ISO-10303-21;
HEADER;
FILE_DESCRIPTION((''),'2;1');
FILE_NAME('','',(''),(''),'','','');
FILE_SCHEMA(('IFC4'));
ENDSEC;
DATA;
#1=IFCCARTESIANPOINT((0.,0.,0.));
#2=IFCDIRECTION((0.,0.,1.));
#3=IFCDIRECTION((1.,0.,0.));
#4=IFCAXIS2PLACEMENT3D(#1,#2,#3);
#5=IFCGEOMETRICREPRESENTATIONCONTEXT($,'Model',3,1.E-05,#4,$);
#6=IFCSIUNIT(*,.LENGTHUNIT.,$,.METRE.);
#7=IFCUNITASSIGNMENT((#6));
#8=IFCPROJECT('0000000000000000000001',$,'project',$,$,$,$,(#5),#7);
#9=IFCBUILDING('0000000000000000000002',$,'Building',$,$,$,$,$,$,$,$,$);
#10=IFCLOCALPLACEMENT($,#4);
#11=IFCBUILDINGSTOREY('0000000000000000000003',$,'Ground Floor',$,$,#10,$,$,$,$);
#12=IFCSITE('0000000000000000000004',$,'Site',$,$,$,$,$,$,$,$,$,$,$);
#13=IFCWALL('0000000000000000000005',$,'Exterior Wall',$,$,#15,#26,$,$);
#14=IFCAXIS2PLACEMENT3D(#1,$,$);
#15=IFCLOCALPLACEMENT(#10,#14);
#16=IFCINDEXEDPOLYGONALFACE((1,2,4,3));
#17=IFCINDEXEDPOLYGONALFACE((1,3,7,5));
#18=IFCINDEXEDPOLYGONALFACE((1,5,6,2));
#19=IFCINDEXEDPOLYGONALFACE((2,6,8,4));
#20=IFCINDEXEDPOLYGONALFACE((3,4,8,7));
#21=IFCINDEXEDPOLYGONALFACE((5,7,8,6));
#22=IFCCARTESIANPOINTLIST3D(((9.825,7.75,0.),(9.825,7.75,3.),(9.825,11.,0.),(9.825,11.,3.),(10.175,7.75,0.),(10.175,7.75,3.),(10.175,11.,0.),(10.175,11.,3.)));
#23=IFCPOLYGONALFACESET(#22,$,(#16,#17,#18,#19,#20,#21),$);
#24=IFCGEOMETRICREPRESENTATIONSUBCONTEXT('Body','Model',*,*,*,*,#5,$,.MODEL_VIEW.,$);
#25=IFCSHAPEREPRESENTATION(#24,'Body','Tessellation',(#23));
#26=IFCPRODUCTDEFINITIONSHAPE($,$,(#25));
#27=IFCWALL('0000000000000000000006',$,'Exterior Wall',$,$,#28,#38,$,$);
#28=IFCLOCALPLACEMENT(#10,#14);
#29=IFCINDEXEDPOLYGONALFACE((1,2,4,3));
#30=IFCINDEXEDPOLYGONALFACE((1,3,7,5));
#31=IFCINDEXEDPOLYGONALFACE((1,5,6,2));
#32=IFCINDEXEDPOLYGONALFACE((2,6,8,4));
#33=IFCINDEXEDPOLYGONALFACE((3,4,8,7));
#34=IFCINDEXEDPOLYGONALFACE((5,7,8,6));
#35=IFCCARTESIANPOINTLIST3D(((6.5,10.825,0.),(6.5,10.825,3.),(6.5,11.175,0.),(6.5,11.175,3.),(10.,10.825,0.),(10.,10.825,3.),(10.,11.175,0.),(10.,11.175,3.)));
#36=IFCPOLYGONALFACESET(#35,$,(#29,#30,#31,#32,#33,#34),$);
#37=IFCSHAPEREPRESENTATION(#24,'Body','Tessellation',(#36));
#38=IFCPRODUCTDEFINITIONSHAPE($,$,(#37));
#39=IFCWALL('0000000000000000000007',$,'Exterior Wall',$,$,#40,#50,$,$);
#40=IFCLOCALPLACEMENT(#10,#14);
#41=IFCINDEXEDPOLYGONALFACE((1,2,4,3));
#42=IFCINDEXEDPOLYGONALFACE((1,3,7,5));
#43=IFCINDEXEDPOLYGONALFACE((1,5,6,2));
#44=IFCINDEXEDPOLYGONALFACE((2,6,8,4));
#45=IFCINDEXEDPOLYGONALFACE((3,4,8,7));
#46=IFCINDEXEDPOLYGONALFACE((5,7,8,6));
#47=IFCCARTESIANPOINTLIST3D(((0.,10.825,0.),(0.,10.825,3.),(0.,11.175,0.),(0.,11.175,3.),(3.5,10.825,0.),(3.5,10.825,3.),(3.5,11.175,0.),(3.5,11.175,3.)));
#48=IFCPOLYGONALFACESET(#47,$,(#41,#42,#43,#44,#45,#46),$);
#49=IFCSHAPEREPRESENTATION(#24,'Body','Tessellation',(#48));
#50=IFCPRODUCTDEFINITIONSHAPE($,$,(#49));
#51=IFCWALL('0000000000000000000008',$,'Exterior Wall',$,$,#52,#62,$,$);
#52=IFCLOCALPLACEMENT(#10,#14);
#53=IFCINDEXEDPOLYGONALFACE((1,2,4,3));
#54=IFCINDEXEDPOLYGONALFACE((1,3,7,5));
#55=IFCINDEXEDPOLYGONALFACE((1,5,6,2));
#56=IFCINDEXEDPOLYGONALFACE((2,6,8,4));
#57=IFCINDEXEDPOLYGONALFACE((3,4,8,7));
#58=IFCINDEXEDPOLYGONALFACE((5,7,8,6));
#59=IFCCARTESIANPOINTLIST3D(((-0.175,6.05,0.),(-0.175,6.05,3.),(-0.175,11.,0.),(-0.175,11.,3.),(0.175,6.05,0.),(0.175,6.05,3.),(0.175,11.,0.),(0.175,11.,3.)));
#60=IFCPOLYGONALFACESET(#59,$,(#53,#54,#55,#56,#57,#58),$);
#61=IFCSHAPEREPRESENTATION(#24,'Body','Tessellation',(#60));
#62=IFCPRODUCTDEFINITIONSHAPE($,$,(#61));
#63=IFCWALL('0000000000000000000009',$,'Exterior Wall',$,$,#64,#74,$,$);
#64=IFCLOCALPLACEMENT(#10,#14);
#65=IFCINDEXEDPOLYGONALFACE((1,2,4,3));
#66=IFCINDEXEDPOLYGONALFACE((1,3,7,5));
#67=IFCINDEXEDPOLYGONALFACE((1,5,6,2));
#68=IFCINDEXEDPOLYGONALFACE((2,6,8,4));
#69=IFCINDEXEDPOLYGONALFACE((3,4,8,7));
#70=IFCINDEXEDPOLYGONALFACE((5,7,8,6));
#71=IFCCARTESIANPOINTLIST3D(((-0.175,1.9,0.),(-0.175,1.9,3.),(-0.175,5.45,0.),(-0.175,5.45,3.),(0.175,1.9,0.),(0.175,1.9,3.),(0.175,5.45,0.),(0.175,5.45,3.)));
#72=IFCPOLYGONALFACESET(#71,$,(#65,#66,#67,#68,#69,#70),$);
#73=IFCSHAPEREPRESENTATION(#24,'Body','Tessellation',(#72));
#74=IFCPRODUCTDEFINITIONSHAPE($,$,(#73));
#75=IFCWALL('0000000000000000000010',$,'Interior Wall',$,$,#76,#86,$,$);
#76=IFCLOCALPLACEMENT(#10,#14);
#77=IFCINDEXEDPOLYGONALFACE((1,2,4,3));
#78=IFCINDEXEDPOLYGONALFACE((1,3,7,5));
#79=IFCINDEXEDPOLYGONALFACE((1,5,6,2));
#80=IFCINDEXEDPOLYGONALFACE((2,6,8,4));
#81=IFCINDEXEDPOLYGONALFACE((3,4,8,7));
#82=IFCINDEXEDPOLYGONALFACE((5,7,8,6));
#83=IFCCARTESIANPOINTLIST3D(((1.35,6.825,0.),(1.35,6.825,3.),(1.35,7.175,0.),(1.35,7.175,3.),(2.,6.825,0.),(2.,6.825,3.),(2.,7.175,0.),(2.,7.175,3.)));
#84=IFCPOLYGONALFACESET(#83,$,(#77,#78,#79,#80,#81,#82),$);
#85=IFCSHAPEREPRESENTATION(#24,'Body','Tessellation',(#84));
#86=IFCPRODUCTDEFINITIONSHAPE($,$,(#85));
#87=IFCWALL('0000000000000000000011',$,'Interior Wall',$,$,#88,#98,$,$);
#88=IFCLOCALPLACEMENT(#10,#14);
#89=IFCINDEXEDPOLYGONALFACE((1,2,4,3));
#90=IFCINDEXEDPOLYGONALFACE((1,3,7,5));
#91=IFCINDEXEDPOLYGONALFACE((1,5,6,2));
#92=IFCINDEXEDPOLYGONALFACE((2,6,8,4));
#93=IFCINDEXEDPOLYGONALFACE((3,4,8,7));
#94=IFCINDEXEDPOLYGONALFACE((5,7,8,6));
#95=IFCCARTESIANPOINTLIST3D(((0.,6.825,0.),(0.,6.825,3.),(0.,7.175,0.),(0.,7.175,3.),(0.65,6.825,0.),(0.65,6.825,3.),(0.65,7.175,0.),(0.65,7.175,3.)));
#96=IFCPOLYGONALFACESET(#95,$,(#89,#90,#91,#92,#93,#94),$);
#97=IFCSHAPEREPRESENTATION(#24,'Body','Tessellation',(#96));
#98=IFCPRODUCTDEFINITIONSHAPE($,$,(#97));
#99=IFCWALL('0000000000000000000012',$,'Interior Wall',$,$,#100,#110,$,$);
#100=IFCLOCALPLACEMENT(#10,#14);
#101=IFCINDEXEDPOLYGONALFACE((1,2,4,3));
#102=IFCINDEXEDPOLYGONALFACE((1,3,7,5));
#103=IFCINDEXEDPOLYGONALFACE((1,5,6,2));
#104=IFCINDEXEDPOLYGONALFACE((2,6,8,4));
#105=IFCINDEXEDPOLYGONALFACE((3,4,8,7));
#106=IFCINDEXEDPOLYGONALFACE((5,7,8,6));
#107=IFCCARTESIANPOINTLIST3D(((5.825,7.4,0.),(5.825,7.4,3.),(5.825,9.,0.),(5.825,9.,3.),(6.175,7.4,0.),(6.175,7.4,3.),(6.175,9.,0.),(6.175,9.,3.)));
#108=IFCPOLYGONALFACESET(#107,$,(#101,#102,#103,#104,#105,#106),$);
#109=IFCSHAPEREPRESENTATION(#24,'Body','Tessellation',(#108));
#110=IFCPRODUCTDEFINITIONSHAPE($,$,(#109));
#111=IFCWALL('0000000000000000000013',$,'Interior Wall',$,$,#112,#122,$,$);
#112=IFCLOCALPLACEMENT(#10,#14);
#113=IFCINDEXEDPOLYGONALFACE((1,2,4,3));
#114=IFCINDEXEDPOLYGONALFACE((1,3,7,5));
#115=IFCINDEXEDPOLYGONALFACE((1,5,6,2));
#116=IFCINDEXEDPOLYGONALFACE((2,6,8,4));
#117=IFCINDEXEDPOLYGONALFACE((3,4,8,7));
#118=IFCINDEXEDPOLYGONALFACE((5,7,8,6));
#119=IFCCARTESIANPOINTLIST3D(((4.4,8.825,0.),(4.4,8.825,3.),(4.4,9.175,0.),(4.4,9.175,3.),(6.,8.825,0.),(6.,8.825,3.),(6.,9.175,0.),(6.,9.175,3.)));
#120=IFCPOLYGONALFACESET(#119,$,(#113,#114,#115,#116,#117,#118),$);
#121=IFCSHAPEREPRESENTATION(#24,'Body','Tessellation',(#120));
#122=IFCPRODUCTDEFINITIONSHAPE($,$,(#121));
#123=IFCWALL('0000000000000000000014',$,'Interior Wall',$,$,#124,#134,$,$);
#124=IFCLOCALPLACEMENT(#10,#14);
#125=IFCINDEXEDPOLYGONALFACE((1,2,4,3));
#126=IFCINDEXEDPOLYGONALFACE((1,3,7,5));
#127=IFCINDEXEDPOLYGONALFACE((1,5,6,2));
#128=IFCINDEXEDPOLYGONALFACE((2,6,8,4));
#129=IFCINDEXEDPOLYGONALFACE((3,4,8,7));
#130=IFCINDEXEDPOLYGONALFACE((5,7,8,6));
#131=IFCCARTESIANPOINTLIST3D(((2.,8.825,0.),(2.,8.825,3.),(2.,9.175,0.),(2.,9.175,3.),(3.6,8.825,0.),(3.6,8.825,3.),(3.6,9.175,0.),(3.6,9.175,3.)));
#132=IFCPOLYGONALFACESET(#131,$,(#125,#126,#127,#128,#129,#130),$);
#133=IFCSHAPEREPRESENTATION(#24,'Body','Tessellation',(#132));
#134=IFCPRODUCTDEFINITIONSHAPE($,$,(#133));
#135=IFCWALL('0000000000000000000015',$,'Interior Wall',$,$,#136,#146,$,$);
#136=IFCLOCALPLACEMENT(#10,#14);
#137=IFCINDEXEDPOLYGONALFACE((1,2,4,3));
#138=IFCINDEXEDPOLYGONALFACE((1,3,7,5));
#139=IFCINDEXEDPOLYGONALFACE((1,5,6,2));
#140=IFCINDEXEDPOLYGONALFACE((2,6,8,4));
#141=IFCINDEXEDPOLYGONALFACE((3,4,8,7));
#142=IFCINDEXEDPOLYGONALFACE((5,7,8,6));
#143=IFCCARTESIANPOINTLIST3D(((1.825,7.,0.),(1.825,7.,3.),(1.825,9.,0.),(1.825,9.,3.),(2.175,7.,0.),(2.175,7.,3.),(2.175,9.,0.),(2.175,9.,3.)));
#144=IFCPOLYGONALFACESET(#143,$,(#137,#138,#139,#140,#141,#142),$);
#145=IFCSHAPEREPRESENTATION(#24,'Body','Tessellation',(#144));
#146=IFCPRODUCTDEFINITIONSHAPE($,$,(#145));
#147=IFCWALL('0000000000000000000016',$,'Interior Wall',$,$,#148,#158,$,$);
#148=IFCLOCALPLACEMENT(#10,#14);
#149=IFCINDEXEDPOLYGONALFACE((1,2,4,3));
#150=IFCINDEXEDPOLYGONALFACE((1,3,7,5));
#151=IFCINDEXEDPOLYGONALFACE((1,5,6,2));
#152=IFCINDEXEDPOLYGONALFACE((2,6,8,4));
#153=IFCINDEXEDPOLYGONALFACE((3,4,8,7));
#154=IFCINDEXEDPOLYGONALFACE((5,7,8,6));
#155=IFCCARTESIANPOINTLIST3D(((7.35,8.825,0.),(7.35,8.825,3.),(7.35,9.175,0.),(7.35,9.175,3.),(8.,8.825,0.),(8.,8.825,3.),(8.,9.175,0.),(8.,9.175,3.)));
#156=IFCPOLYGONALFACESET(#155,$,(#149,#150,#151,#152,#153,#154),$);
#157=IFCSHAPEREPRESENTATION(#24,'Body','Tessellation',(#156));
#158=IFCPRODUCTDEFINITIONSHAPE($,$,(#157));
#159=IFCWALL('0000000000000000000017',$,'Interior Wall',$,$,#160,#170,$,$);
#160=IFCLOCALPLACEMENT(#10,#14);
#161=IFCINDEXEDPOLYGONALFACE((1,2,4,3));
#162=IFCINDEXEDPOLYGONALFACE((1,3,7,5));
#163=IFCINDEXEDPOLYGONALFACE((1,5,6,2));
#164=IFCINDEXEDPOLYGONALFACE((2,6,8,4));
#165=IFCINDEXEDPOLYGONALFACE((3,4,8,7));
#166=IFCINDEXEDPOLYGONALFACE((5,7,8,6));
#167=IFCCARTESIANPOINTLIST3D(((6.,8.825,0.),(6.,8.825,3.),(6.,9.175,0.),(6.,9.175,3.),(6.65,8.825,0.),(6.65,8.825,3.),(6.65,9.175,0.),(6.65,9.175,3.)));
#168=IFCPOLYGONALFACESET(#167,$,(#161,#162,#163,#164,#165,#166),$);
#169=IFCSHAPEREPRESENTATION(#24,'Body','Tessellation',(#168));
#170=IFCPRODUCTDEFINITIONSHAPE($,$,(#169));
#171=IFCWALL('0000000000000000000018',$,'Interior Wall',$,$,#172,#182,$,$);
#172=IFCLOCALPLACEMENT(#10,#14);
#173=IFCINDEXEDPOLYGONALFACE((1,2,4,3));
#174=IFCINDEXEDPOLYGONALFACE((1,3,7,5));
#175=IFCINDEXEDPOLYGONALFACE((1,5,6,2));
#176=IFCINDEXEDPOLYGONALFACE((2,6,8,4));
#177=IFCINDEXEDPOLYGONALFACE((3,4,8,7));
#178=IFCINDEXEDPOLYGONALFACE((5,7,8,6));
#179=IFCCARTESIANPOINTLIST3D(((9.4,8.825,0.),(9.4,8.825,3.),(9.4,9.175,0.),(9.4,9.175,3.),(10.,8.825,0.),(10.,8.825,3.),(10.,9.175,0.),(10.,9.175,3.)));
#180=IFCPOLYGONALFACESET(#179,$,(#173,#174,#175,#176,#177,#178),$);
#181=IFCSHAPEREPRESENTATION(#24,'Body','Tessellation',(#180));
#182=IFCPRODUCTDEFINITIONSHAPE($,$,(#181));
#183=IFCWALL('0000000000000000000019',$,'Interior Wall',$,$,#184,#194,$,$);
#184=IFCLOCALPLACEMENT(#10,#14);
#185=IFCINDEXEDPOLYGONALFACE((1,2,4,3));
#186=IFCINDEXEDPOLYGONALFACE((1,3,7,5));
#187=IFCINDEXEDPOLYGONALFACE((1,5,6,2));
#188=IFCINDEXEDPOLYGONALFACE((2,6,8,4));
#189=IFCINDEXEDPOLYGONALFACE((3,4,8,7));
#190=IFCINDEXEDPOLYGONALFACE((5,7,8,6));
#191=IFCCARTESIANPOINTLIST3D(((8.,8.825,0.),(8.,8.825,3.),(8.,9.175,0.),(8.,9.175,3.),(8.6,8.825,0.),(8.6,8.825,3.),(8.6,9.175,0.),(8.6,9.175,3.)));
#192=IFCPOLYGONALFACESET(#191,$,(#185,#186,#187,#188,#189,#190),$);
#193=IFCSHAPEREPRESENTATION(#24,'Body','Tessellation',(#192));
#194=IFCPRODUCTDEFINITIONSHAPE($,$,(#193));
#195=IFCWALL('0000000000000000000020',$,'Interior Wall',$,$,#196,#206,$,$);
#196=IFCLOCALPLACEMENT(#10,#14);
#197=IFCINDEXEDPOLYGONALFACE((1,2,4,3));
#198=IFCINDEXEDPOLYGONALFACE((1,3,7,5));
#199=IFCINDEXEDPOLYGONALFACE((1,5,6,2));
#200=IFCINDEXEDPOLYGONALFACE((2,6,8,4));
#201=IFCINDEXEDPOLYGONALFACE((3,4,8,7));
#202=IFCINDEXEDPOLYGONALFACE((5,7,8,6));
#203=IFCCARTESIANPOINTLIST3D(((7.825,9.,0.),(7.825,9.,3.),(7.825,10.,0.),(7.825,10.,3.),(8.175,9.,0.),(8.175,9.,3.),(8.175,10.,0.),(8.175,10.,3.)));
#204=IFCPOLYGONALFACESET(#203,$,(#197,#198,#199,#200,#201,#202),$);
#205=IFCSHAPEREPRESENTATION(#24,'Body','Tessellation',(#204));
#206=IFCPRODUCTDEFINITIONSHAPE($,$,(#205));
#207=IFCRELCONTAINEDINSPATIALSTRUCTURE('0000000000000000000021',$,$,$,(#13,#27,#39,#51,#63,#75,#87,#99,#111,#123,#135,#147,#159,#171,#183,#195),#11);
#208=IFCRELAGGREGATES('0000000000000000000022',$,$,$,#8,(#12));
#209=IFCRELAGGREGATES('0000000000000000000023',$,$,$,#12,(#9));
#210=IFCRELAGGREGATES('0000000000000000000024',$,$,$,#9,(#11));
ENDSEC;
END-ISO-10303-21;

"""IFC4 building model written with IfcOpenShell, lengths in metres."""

from ifc_helpers import new_model, si_unit, frame, origin_with_axes, place, context, subcontext, project, spatial, indexed_curve, outline, extrude, element, save


model = new_model("IFC4")

# Units and contexts
model_context = context("Model", 3, precision=1e-05, world=origin_with_axes())
body_context = subcontext(model_context, "Body", "Model", "MODEL_VIEW")
ifc_project = project(units=[si_unit("LENGTHUNIT", "METRE")], contexts=[model_context])

# Site, building, storey
site = spatial("IfcSite", under=ifc_project, Name="Site")
building = spatial("IfcBuilding", under=site, Name="Building")
storey_placement = place(None, origin_with_axes())
storey = spatial("IfcBuildingStorey", under=building, at=storey_placement, Name="Ground Floor")

# Walls
wall_1_placement = place(storey_placement, frame((10.0, 7.75, 0.0), z_axis=(0.0, 0.0, 1.0), x_axis=(0.0, 1.0, 0.0)))
element("IfcWall", 1, at=wall_1_placement, inside=storey, Name="Exterior Wall", context=body_context, shape_type="SweptSolid", body=[
    extrude(outline(indexed_curve([(0.0, 0.0), (0.0, 0.35), (3.25, 0.35), (3.25, 0.0), (0.0, 0.0)], self_intersect=False)), frame((0.0, -0.175, 0.0), z_axis=(0.0, 0.0, 1.0), x_axis=(1.0, 0.0, 0.0)), (0.0, 0.0, 1.0), 3.0),
])
for number, where, z_axis, x_axis, name in (
    (2, (10.0, 11.0, 0.0), (0.0, 0.0, 1.0), (-1.0, 0.0, 0.0), "Exterior Wall"),
    (3, (3.5, 11.0, 0.0), (0.0, 0.0, 1.0), (-1.0, 0.0, 0.0), "Exterior Wall"),
):
    element("IfcWall", number, at=place(storey_placement, frame(where, z_axis=z_axis, x_axis=x_axis)), inside=storey, Name=name, context=body_context, shape_type="SweptSolid", body=[
        extrude(outline(indexed_curve([(0.0, 0.0), (0.0, 0.35), (3.5, 0.35), (3.5, 0.0), (0.0, 0.0)], self_intersect=False)), frame((0.0, -0.175, 0.0), z_axis=(0.0, 0.0, 1.0), x_axis=(1.0, 0.0, 0.0)), (0.0, 0.0, 1.0), 3.0),
    ])
wall_2_placement = place(storey_placement, frame((0.0, 11.0, 0.0), z_axis=(0.0, 0.0, 1.0), x_axis=(0.0, -1.0, 0.0)))
element("IfcWall", 4, at=wall_2_placement, inside=storey, Name="Exterior Wall", context=body_context, shape_type="SweptSolid", body=[
    extrude(outline(indexed_curve([(0.0, 0.0), (0.0, 0.35), (4.95, 0.35), (4.95, 0.0), (0.0, 0.0)], self_intersect=False)), frame((0.0, -0.175, 0.0), z_axis=(0.0, 0.0, 1.0), x_axis=(1.0, 0.0, 0.0)), (0.0, 0.0, 1.0), 3.0),
])
wall_3_placement = place(storey_placement, frame((0.0, 5.45, 0.0), z_axis=(0.0, 0.0, 1.0), x_axis=(0.0, -1.0, 0.0)))
element("IfcWall", 5, at=wall_3_placement, inside=storey, Name="Exterior Wall", context=body_context, shape_type="SweptSolid", body=[
    extrude(outline(indexed_curve([(0.0, 0.0), (0.0, 0.35), (3.55, 0.35), (3.55, 0.0), (0.0, 0.0)], self_intersect=False)), frame((0.0, -0.175, 0.0), z_axis=(0.0, 0.0, 1.0), x_axis=(1.0, 0.0, 0.0)), (0.0, 0.0, 1.0), 3.0),
])
for number, where, z_axis, x_axis, name in (
    (6, (2.0, 7.0, 0.0), (0.0, 0.0, 1.0), (-1.0, 0.0, 0.0), "Interior Wall"),
    (7, (0.65, 7.0, 0.0), (0.0, 0.0, 1.0), (-1.0, 0.0, 0.0), "Interior Wall"),
):
    element("IfcWall", number, at=place(storey_placement, frame(where, z_axis=z_axis, x_axis=x_axis)), inside=storey, Name=name, context=body_context, shape_type="SweptSolid", body=[
        extrude(outline(indexed_curve([(0.0, 0.0), (0.0, 0.35), (0.65, 0.35), (0.65, 0.0), (0.0, 0.0)], self_intersect=False)), frame((0.0, -0.175, 0.0), z_axis=(0.0, 0.0, 1.0), x_axis=(1.0, 0.0, 0.0)), (0.0, 0.0, 1.0), 3.0),
    ])
for number, where, z_axis, x_axis, name in (
    (8, (6.0, 7.4, 0.0), (0.0, 0.0, 1.0), (0.0, 1.0, 0.0), "Interior Wall"),
    (9, (6.0, 9.0, 0.0), (0.0, 0.0, 1.0), (-1.0, 0.0, 0.0), "Interior Wall"),
):
    element("IfcWall", number, at=place(storey_placement, frame(where, z_axis=z_axis, x_axis=x_axis)), inside=storey, Name=name, context=body_context, shape_type="SweptSolid", body=[
        extrude(outline(indexed_curve([(0.0, 0.0), (0.0, 0.35), (1.6, 0.35), (1.6, 0.0), (0.0, 0.0)], self_intersect=False)), frame((0.0, -0.175, 0.0), z_axis=(0.0, 0.0, 1.0), x_axis=(1.0, 0.0, 0.0)), (0.0, 0.0, 1.0), 3.0),
    ])
wall_4_placement = place(storey_placement, frame((3.6, 9.0, 0.0), z_axis=(0.0, 0.0, 1.0), x_axis=(-1.0, 0.0, 0.0)))
element("IfcWall", 10, at=wall_4_placement, inside=storey, Name="Interior Wall", context=body_context, shape_type="SweptSolid", body=[
    extrude(outline(indexed_curve([(0.0, 0.0), (0.0, 0.35), (1.6, 0.35), (1.6, 0.0), (0.0, 0.0)], self_intersect=False)), frame((0.0, -0.175, 0.0), z_axis=(0.0, 0.0, 1.0), x_axis=(1.0, 0.0, 0.0)), (0.0, 0.0, 1.0), 3.0),
])
wall_5_placement = place(storey_placement, frame((2.0, 9.0, 0.0), z_axis=(0.0, 0.0, 1.0), x_axis=(0.0, -1.0, 0.0)))
element("IfcWall", 11, at=wall_5_placement, inside=storey, Name="Interior Wall", context=body_context, shape_type="SweptSolid", body=[
    extrude(outline(indexed_curve([(0.0, 0.0), (0.0, 0.35), (2.0, 0.35), (2.0, 0.0), (0.0, 0.0)], self_intersect=False)), frame((0.0, -0.175, 0.0), z_axis=(0.0, 0.0, 1.0), x_axis=(1.0, 0.0, 0.0)), (0.0, 0.0, 1.0), 3.0),
])
for number, where, z_axis, x_axis, name in (
    (12, (8.0, 9.0, 0.0), (0.0, 0.0, 1.0), (-1.0, 0.0, 0.0), "Interior Wall"),
    (13, (6.65, 9.0, 0.0), (0.0, 0.0, 1.0), (-1.0, 0.0, 0.0), "Interior Wall"),
):
    element("IfcWall", number, at=place(storey_placement, frame(where, z_axis=z_axis, x_axis=x_axis)), inside=storey, Name=name, context=body_context, shape_type="SweptSolid", body=[
        extrude(outline(indexed_curve([(0.0, 0.0), (0.0, 0.35), (0.65, 0.35), (0.65, 0.0), (0.0, 0.0)], self_intersect=False)), frame((0.0, -0.175, 0.0), z_axis=(0.0, 0.0, 1.0), x_axis=(1.0, 0.0, 0.0)), (0.0, 0.0, 1.0), 3.0),
    ])
for number, where, z_axis, x_axis, name in (
    (14, (10.0, 9.0, 0.0), (0.0, 0.0, 1.0), (-1.0, 0.0, 0.0), "Interior Wall"),
    (15, (8.6, 9.0, 0.0), (0.0, 0.0, 1.0), (-1.0, 0.0, 0.0), "Interior Wall"),
):
    element("IfcWall", number, at=place(storey_placement, frame(where, z_axis=z_axis, x_axis=x_axis)), inside=storey, Name=name, context=body_context, shape_type="SweptSolid", body=[
        extrude(outline(indexed_curve([(0.0, 0.0), (0.0, 0.35), (0.6, 0.35), (0.6, 0.0), (0.0, 0.0)], self_intersect=False)), frame((0.0, -0.175, 0.0), z_axis=(0.0, 0.0, 1.0), x_axis=(1.0, 0.0, 0.0)), (0.0, 0.0, 1.0), 3.0),
    ])
wall_6_placement = place(storey_placement, frame((8.0, 9.0, 0.0), z_axis=(0.0, 0.0, 1.0), x_axis=(0.0, 1.0, 0.0)))
element("IfcWall", 16, at=wall_6_placement, inside=storey, Name="Interior Wall", context=body_context, shape_type="SweptSolid", body=[
    extrude(outline(indexed_curve([(0.0, 0.0), (0.0, 0.35), (1.0, 0.35), (1.0, 0.0), (0.0, 0.0)], self_intersect=False)), frame((0.0, -0.175, 0.0), z_axis=(0.0, 0.0, 1.0), x_axis=(1.0, 0.0, 0.0)), (0.0, 0.0, 1.0), 3.0),
])

save(model, "model.ifc")
